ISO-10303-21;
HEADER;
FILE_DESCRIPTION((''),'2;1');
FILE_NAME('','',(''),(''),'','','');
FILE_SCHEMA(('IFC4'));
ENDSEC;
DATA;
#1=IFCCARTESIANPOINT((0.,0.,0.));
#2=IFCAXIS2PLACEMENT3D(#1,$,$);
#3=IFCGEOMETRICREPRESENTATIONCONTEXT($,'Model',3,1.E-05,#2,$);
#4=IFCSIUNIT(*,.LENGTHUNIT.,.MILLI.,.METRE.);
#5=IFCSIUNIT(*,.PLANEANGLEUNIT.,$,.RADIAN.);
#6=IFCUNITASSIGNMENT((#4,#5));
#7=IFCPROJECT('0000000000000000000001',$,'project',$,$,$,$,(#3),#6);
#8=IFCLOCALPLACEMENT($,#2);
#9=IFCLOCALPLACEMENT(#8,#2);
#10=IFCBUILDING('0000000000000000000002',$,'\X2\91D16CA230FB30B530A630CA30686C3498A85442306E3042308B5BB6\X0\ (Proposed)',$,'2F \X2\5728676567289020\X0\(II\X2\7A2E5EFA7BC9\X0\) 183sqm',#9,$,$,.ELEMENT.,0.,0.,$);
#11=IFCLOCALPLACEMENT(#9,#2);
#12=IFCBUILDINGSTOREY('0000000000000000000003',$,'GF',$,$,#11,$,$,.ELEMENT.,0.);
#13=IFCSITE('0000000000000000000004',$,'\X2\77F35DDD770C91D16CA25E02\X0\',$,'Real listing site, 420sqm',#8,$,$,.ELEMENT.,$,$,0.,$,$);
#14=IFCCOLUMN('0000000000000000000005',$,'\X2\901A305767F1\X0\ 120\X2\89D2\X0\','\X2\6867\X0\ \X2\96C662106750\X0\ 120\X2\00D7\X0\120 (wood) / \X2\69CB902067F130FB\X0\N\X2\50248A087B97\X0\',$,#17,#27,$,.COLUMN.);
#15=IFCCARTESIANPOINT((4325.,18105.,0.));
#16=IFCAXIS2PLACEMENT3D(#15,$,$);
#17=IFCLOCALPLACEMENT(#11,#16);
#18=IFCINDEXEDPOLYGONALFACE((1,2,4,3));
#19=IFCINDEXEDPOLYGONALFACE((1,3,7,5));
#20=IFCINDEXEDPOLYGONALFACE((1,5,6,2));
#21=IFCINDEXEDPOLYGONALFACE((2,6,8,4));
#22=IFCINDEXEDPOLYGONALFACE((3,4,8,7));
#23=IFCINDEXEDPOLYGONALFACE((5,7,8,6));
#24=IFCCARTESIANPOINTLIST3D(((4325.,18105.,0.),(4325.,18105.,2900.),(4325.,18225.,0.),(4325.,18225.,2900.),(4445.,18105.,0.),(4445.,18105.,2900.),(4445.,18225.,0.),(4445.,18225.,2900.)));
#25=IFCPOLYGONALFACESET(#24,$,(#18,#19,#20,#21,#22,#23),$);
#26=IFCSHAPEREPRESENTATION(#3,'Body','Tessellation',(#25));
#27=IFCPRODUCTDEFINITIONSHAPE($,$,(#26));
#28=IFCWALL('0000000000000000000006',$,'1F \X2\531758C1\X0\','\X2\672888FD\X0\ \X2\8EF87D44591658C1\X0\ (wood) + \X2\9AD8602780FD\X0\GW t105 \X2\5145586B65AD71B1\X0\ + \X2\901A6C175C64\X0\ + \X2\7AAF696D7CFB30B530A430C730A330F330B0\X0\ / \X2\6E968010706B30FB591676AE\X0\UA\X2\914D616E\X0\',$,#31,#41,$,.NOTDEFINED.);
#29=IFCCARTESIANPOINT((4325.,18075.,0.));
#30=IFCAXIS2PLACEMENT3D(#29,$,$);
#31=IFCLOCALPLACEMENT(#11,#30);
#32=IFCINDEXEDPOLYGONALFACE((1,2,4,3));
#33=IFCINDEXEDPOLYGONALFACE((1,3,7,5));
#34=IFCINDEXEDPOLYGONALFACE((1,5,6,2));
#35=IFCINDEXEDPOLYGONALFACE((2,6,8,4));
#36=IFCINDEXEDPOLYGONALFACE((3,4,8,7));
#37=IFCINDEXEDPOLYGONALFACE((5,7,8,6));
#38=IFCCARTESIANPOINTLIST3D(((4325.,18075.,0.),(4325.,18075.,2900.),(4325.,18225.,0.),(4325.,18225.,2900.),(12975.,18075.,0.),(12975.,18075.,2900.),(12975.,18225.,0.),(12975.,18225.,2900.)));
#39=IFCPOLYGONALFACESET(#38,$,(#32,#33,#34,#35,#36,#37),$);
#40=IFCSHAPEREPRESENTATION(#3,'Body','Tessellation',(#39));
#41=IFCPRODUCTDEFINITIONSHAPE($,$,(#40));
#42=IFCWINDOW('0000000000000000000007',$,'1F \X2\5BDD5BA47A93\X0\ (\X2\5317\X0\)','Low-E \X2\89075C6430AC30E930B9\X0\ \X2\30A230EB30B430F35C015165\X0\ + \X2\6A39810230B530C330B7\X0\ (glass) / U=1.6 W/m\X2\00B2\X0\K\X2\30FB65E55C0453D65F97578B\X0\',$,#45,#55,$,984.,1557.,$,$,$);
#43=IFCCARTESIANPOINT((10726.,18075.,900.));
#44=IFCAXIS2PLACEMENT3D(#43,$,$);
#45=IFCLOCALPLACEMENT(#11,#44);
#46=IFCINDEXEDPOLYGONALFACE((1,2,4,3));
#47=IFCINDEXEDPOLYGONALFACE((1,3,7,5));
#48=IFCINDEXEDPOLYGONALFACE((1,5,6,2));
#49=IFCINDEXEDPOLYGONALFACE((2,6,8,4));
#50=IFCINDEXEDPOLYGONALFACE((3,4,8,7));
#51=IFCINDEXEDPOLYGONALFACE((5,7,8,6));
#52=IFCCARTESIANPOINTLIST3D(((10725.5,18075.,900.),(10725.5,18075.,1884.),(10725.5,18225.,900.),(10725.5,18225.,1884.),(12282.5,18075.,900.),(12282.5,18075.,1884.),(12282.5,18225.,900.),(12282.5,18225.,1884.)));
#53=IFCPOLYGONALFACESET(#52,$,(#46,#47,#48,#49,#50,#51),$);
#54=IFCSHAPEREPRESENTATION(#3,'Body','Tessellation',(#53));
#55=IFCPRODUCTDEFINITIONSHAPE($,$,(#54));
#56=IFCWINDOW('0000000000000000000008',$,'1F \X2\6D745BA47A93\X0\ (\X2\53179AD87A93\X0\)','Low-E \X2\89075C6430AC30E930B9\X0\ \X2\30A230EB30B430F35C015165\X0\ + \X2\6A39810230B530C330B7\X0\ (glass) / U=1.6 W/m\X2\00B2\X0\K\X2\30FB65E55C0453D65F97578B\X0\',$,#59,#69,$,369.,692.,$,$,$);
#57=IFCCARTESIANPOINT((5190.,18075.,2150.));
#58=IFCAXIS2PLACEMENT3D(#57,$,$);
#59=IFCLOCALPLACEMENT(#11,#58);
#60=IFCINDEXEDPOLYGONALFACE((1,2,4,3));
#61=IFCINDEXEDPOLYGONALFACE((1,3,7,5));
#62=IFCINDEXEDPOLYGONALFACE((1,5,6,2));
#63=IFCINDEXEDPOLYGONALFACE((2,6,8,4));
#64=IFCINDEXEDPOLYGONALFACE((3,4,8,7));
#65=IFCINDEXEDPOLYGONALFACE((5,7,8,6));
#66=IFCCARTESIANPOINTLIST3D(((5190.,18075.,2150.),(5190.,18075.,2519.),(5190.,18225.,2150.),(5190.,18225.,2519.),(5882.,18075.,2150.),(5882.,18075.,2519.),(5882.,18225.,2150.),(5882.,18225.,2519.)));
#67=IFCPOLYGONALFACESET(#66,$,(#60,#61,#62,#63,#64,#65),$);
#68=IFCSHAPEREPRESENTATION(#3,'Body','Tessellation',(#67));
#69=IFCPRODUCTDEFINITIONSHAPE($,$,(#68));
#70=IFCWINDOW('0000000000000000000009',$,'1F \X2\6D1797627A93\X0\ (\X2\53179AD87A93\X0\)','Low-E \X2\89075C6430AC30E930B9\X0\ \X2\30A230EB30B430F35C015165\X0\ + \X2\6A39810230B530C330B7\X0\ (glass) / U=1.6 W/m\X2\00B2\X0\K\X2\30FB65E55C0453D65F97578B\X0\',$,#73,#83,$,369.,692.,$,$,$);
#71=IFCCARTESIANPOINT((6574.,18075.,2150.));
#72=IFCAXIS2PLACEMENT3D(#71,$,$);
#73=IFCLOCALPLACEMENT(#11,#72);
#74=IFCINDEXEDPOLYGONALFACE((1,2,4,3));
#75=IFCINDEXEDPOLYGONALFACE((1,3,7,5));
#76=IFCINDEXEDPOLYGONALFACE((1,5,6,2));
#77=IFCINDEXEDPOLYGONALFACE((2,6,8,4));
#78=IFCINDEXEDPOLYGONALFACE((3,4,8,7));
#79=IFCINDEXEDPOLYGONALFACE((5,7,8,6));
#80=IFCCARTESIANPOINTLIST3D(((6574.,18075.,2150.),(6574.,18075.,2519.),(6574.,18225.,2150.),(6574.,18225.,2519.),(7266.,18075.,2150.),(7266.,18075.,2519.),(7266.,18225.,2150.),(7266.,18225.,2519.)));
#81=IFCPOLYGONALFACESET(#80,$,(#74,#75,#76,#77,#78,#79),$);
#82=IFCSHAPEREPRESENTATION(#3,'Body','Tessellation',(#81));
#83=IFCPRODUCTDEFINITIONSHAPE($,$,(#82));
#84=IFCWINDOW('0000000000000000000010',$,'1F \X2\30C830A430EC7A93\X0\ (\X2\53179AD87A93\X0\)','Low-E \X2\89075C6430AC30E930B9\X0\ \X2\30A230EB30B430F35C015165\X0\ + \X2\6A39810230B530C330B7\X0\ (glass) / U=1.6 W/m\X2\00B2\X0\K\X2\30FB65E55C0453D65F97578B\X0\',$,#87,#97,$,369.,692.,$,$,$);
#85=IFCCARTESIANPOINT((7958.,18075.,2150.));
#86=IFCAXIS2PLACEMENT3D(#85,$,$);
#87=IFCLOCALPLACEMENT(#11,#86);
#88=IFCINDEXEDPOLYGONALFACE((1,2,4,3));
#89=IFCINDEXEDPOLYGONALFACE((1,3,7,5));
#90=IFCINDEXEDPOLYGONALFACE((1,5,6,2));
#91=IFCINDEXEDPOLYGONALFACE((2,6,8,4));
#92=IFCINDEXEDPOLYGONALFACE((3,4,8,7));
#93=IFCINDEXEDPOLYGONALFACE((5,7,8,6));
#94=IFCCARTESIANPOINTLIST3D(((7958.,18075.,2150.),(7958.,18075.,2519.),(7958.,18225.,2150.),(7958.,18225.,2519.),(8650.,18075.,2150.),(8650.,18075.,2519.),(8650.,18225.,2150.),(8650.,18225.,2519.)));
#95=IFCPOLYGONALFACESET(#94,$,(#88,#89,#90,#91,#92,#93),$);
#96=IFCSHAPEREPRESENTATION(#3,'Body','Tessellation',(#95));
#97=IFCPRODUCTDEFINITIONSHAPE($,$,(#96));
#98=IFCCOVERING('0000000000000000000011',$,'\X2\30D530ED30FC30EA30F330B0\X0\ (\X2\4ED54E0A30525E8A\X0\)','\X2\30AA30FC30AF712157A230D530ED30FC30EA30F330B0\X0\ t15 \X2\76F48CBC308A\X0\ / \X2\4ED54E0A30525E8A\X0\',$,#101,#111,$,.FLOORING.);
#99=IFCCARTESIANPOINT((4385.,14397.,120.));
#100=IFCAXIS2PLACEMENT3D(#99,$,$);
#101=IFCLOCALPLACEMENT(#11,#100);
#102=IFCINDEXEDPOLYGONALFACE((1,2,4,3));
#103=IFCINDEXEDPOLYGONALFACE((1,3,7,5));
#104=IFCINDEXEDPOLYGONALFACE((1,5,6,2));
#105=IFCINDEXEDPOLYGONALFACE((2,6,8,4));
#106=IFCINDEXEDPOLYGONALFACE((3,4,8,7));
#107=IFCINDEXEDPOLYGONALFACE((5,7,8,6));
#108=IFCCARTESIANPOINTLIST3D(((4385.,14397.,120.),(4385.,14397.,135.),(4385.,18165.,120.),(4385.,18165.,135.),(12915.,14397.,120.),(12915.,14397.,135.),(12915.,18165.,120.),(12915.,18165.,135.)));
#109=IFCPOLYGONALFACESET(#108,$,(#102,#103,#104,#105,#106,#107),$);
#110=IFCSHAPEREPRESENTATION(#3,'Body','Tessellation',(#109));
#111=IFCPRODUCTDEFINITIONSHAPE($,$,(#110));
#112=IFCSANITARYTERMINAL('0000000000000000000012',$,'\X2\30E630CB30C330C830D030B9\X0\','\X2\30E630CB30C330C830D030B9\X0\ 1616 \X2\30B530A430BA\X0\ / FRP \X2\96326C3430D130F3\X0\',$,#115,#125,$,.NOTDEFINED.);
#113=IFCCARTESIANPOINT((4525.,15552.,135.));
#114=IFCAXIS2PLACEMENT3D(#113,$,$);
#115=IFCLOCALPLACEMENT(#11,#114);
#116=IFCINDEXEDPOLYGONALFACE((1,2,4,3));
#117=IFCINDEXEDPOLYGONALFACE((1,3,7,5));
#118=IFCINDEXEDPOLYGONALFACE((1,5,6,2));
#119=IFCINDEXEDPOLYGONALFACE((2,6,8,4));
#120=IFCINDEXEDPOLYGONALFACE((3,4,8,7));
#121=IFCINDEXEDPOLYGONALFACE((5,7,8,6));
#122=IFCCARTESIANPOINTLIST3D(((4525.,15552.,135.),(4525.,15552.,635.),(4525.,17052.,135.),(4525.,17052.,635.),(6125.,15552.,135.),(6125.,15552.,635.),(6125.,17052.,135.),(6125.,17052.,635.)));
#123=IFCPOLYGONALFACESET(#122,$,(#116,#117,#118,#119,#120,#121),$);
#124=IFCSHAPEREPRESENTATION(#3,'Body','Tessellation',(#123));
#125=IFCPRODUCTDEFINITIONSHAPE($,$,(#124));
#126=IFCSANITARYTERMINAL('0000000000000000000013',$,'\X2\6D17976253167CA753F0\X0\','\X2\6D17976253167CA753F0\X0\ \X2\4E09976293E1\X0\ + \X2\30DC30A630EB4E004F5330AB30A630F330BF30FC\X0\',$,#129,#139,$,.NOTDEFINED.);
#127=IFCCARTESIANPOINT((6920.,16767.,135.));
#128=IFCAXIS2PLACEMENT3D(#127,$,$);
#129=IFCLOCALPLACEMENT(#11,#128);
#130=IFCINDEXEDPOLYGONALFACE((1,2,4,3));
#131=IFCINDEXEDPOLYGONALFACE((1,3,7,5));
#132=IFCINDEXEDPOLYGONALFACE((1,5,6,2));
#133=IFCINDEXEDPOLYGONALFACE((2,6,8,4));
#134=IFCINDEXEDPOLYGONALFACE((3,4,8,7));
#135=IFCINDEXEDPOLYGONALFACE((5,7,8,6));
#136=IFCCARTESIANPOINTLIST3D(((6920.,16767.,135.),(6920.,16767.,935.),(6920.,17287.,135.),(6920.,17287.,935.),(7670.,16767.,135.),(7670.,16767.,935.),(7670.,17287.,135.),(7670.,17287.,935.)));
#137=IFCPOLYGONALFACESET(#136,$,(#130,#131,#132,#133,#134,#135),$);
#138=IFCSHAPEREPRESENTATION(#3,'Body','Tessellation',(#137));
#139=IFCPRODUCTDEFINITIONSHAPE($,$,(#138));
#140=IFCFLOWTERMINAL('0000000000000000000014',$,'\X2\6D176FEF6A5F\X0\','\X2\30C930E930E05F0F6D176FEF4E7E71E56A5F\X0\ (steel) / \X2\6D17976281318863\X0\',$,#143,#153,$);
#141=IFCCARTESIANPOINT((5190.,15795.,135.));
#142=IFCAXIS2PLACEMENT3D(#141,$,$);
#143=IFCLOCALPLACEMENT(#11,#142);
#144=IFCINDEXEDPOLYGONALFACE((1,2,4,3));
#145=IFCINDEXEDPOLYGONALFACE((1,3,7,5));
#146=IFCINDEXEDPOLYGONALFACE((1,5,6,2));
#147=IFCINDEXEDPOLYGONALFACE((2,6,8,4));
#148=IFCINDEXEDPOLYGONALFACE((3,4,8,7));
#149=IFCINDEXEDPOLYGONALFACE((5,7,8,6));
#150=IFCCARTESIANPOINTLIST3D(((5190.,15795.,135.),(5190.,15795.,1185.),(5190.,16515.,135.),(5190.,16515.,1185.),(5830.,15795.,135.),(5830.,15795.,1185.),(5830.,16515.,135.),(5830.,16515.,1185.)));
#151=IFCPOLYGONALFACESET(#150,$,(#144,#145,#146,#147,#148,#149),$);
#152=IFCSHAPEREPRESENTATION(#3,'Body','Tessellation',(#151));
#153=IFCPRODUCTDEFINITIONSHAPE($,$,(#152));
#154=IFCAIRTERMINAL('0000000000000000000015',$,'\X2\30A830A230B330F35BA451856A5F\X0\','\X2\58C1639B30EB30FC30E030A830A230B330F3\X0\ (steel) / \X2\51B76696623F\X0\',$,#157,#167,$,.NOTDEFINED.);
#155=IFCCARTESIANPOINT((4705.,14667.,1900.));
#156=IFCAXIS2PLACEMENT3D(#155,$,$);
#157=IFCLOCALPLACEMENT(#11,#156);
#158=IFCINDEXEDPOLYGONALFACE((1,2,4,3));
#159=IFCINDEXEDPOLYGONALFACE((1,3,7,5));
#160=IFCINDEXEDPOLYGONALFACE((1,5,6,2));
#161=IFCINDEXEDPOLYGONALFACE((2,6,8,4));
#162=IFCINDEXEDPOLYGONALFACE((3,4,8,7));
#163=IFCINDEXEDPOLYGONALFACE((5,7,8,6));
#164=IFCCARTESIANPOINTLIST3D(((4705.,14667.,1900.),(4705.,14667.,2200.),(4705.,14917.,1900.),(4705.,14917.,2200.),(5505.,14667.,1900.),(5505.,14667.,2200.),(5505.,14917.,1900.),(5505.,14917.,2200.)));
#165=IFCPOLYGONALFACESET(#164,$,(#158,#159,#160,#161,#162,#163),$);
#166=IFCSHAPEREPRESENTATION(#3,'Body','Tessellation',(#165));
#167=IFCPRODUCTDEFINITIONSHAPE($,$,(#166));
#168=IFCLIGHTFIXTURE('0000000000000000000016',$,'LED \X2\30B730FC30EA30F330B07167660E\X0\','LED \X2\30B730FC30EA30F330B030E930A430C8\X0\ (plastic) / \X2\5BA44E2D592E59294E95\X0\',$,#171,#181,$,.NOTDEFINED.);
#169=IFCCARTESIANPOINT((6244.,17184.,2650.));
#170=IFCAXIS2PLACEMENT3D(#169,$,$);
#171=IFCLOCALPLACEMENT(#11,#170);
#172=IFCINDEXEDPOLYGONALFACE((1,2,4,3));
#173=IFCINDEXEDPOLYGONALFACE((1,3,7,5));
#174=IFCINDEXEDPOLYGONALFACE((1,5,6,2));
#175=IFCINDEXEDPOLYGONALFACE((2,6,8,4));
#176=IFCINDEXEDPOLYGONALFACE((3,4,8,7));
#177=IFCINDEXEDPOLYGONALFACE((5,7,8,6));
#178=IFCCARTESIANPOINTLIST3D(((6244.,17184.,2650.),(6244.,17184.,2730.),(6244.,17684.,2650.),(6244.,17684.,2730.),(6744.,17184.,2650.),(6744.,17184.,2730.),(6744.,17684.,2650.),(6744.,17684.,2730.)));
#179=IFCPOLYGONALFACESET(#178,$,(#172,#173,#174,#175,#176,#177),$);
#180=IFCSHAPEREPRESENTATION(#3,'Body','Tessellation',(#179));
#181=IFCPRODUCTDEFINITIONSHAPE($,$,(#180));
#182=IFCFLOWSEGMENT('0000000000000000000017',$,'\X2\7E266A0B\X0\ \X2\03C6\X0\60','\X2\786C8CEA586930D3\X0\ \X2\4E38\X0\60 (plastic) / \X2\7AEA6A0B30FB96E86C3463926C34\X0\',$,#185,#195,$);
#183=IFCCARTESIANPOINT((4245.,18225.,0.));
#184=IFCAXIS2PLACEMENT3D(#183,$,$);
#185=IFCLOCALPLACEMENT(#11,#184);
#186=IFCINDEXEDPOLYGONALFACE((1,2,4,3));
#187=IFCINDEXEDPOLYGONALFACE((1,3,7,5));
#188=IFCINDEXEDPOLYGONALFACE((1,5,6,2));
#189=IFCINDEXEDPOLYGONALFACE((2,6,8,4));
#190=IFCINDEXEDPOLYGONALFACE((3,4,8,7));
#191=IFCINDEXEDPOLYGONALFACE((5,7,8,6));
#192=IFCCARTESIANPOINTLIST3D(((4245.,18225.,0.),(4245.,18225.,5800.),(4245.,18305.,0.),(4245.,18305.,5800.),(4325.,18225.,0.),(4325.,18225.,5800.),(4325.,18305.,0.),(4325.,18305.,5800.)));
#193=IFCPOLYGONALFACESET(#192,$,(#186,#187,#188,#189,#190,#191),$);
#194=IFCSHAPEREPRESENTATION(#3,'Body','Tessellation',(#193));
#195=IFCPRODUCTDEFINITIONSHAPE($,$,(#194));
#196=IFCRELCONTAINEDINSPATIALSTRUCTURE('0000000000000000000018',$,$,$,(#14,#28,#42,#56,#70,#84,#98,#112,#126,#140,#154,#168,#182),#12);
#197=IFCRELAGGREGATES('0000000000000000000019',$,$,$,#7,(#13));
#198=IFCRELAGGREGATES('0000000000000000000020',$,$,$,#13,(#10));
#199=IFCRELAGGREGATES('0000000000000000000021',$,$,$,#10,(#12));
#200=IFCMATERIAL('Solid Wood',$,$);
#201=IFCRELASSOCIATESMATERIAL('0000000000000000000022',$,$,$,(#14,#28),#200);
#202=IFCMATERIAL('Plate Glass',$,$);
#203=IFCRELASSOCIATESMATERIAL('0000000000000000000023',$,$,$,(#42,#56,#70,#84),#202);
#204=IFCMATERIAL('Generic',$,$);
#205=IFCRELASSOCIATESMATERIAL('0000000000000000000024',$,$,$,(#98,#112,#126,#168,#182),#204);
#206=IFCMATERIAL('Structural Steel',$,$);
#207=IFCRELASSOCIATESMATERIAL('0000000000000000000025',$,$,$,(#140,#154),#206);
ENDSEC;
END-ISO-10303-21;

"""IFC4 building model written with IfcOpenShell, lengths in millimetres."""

from ifc_helpers import new_model, si_unit, frame, frame_2d, origin, place, context, project, spatial, rectangle, extrude, material, element, fill, save


model = new_model("IFC4")

# Units and contexts
model_context = context("Model", 3, precision=1e-05, world=origin())
ifc_project = project(units=[si_unit("LENGTHUNIT", "METRE", prefix="MILLI"), si_unit("PLANEANGLEUNIT", "RADIAN")], contexts=[model_context])

# Site, building, storey
site_placement = place(None, origin())
site = spatial("IfcSite", under=ifc_project, at=site_placement, Name="石川県金沢市", ObjectType="Real listing site, 420sqm", CompositionType="ELEMENT", RefElevation=0.0)
building_placement = place(site_placement, origin())
building = spatial("IfcBuilding", under=site, at=building_placement, Name="金沢・サウナと水風呂のある家 (Proposed)", ObjectType="2F 在来木造(II種建築) 183sqm", CompositionType="ELEMENT", ElevationOfRefHeight=0.0, ElevationOfTerrain=0.0)
storey_placement = place(building_placement, origin())
storey = spatial("IfcBuildingStorey", under=building, at=storey_placement, Name="GF", CompositionType="ELEMENT", Elevation=0.0)

# Column
ifc_material_1 = material(Name="Solid Wood")
column_1_placement = place(storey_placement, frame((4325.0, 18105.0, 0.0)))
element("IfcColumn", 1, at=column_1_placement, inside=storey, material=ifc_material_1, Name="通し柱 120角", Description="桧 集成材 120×120 (wood) / 構造柱・N値計算", PredefinedType="COLUMN", context=model_context, shape_type="SweptSolid", body=[
    extrude(rectangle(XDim=120.0, YDim=120.0, at=frame_2d((60.0, 60.0))), frame((4325.0, 18105.0, 0.0)), (0.0, 0.0, 1.0), 2900.0),
])

# Wall, openings, windows
wall_1_placement = place(storey_placement, frame((4325.0, 18075.0, 0.0)))
wall_1 = element("IfcWall", 2, at=wall_1_placement, inside=storey, material=ifc_material_1, Name="1F 北壁", Description="木製 軸組外壁 (wood) + 高性能GW t105 充填断熱 + 通気層 + 窯業系サイディング / 準耐火・外皮UA配慮", PredefinedType="NOTDEFINED", context=model_context, shape_type="SweptSolid", body=[
    extrude(rectangle(XDim=8650.0, YDim=150.0, at=frame_2d((4325.0, 75.0))), frame((4325.0, 18075.0, 0.0)), (0.0, 0.0, 1.0), 2900.0),
])
opening_1_placement = place(storey_placement, frame((10726.0, 18075.0, 900.0)))
opening_1 = element("IfcOpeningElement", 3, at=opening_1_placement, cuts=wall_1, PredefinedType="NOTDEFINED", context=model_context, shape_type="SweptSolid", body=[
    extrude(rectangle(XDim=1557.0, YDim=150.0, at=frame_2d((778.0, 75.0))), frame((10726.0, 18075.0, 900.0)), (0.0, 0.0, 1.0), 984.0),
])
opening_2_placement = place(storey_placement, frame((5190.0, 18075.0, 2150.0)))
opening_2 = element("IfcOpeningElement", 4, at=opening_2_placement, cuts=wall_1, PredefinedType="NOTDEFINED", context=model_context, shape_type="SweptSolid", body=[
    extrude(rectangle(XDim=692.0, YDim=150.0, at=frame_2d((346.0, 75.0))), frame((5190.0, 18075.0, 2150.0)), (0.0, 0.0, 1.0), 369.0),
])
opening_3_placement = place(storey_placement, frame((6574.0, 18075.0, 2150.0)))
opening_3 = element("IfcOpeningElement", 5, at=opening_3_placement, cuts=wall_1, PredefinedType="NOTDEFINED", context=model_context, shape_type="SweptSolid", body=[
    extrude(rectangle(XDim=692.0, YDim=150.0, at=frame_2d((346.0, 75.0))), frame((6574.0, 18075.0, 2150.0)), (0.0, 0.0, 1.0), 369.0),
])
opening_4_placement = place(storey_placement, frame((7958.0, 18075.0, 2150.0)))
opening_4 = element("IfcOpeningElement", 6, at=opening_4_placement, cuts=wall_1, PredefinedType="NOTDEFINED", context=model_context, shape_type="SweptSolid", body=[
    extrude(rectangle(XDim=692.0, YDim=150.0, at=frame_2d((346.0, 75.0))), frame((7958.0, 18075.0, 2150.0)), (0.0, 0.0, 1.0), 369.0),
])
ifc_material_2 = material(Name="Plate Glass")
window_1_placement = place(storey_placement, frame((10726.0, 18075.0, 900.0)))
window_1 = element("IfcWindow", 7, at=window_1_placement, inside=storey, material=ifc_material_2, Name="1F 寝室窓 (北)", Description="Low-E 複層ガラス アルゴン封入 + 樹脂サッシ (glass) / U=1.6 W/m²K・日射取得型", OverallHeight=984.0, OverallWidth=1557.0, context=model_context, shape_type="SweptSolid", body=[
    extrude(rectangle(XDim=1557.0, YDim=150.0, at=frame_2d((778.0, 75.0))), frame((10726.0, 18075.0, 900.0)), (0.0, 0.0, 1.0), 984.0),
])
fill(opening_1, window_1)
window_2_placement = place(storey_placement, frame((5190.0, 18075.0, 2150.0)))
window_2 = element("IfcWindow", 8, at=window_2_placement, inside=storey, material=ifc_material_2, Name="1F 浴室窓 (北高窓)", Description="Low-E 複層ガラス アルゴン封入 + 樹脂サッシ (glass) / U=1.6 W/m²K・日射取得型", OverallHeight=369.0, OverallWidth=692.0, context=model_context, shape_type="SweptSolid", body=[
    extrude(rectangle(XDim=692.0, YDim=150.0, at=frame_2d((346.0, 75.0))), frame((5190.0, 18075.0, 2150.0)), (0.0, 0.0, 1.0), 369.0),
])
fill(opening_2, window_2)
window_3_placement = place(storey_placement, frame((6574.0, 18075.0, 2150.0)))
window_3 = element("IfcWindow", 9, at=window_3_placement, inside=storey, material=ifc_material_2, Name="1F 洗面窓 (北高窓)", Description="Low-E 複層ガラス アルゴン封入 + 樹脂サッシ (glass) / U=1.6 W/m²K・日射取得型", OverallHeight=369.0, OverallWidth=692.0, context=model_context, shape_type="SweptSolid", body=[
    extrude(rectangle(XDim=692.0, YDim=150.0, at=frame_2d((346.0, 75.0))), frame((6574.0, 18075.0, 2150.0)), (0.0, 0.0, 1.0), 369.0),
])
fill(opening_3, window_3)
window_4_placement = place(storey_placement, frame((7958.0, 18075.0, 2150.0)))
window_4 = element("IfcWindow", 10, at=window_4_placement, inside=storey, material=ifc_material_2, Name="1F トイレ窓 (北高窓)", Description="Low-E 複層ガラス アルゴン封入 + 樹脂サッシ (glass) / U=1.6 W/m²K・日射取得型", OverallHeight=369.0, OverallWidth=692.0, context=model_context, shape_type="SweptSolid", body=[
    extrude(rectangle(XDim=692.0, YDim=150.0, at=frame_2d((346.0, 75.0))), frame((7958.0, 18075.0, 2150.0)), (0.0, 0.0, 1.0), 369.0),
])
fill(opening_4, window_4)

# Covering
ifc_material_3 = material(Name="Generic")
covering_placement = place(storey_placement, frame((4385.0, 14397.0, 120.0)))
element("IfcCovering", 11, at=covering_placement, inside=storey, material=ifc_material_3, Name="フローリング (仕上げ床)", Description="オーク無垢フローリング t15 直貼り / 仕上げ床", PredefinedType="FLOORING", context=model_context, shape_type="SweptSolid", body=[
    extrude(rectangle(XDim=8530.0, YDim=3768.0, at=frame_2d((4265.0, 1884.0))), frame((4385.0, 14397.0, 120.0)), (0.0, 0.0, 1.0), 15.0),
])

# Sanitary terminals
sanitary_terminal_1_placement = place(storey_placement, frame((4525.0, 15552.0, 135.0)))
element("IfcSanitaryTerminal", 12, at=sanitary_terminal_1_placement, inside=storey, material=ifc_material_3, Name="ユニットバス", Description="ユニットバス 1616 サイズ / FRP 防水パン", PredefinedType="NOTDEFINED", context=model_context, shape_type="SweptSolid", body=[
    extrude(rectangle(XDim=1600.0, YDim=1500.0, at=frame_2d((800.0, 750.0))), frame((4525.0, 15552.0, 135.0)), (0.0, 0.0, 1.0), 500.0),
])
sanitary_terminal_2_placement = place(storey_placement, frame((6920.0, 16767.0, 135.0)))
element("IfcSanitaryTerminal", 13, at=sanitary_terminal_2_placement, inside=storey, material=ifc_material_3, Name="洗面化粧台", Description="洗面化粧台 三面鏡 + ボウル一体カウンター", PredefinedType="NOTDEFINED", context=model_context, shape_type="SweptSolid", body=[
    extrude(rectangle(XDim=750.0, YDim=520.0, at=frame_2d((375.0, 260.0))), frame((6920.0, 16767.0, 135.0)), (0.0, 0.0, 1.0), 800.0),
])

# Flow terminal
ifc_material_4 = material(Name="Structural Steel")
flow_terminal_placement = place(storey_placement, frame((5190.0, 15795.0, 135.0)))
element("IfcFlowTerminal", 14, at=flow_terminal_placement, inside=storey, material=ifc_material_4, Name="洗濯機", Description="ドラム式洗濯乾燥機 (steel) / 洗面脱衣", context=model_context, shape_type="SweptSolid", body=[
    extrude(rectangle(XDim=640.0, YDim=720.0, at=frame_2d((320.0, 360.0))), frame((5190.0, 15795.0, 135.0)), (0.0, 0.0, 1.0), 1050.0),
])

# Air terminal
air_terminal_placement = place(storey_placement, frame((4705.0, 14667.0, 1900.0)))
element("IfcAirTerminal", 15, at=air_terminal_placement, inside=storey, material=ifc_material_4, Name="エアコン室内機", Description="壁掛ルームエアコン (steel) / 冷暖房", PredefinedType="NOTDEFINED", context=model_context, shape_type="SweptSolid", body=[
    extrude(rectangle(XDim=800.0, YDim=250.0, at=frame_2d((400.0, 125.0))), frame((4705.0, 14667.0, 1900.0)), (0.0, 0.0, 1.0), 300.0),
])

# Light fixture
light_fixture_placement = place(storey_placement, frame((6244.0, 17184.0, 2650.0)))
element("IfcLightFixture", 16, at=light_fixture_placement, inside=storey, material=ifc_material_3, Name="LED シーリング照明", Description="LED シーリングライト (plastic) / 室中央天井", PredefinedType="NOTDEFINED", context=model_context, shape_type="SweptSolid", body=[
    extrude(rectangle(XDim=500.0, YDim=500.0, at=frame_2d((250.0, 250.0))), frame((6244.0, 17184.0, 2650.0)), (0.0, 0.0, 1.0), 80.0),
])

# Flow segment
flow_segment_placement = place(storey_placement, frame((4245.0, 18225.0, 0.0)))
element("IfcFlowSegment", 17, at=flow_segment_placement, inside=storey, material=ifc_material_3, Name="縦樋 φ60", Description="硬質塩ビ 丸60 (plastic) / 竪樋・雨水排水", context=model_context, shape_type="SweptSolid", body=[
    extrude(rectangle(XDim=80.0, YDim=80.0, at=frame_2d((40.0, 40.0))), frame((4245.0, 18225.0, 0.0)), (0.0, 0.0, 1.0), 5800.0),
])

save(model, "model.ifc")
